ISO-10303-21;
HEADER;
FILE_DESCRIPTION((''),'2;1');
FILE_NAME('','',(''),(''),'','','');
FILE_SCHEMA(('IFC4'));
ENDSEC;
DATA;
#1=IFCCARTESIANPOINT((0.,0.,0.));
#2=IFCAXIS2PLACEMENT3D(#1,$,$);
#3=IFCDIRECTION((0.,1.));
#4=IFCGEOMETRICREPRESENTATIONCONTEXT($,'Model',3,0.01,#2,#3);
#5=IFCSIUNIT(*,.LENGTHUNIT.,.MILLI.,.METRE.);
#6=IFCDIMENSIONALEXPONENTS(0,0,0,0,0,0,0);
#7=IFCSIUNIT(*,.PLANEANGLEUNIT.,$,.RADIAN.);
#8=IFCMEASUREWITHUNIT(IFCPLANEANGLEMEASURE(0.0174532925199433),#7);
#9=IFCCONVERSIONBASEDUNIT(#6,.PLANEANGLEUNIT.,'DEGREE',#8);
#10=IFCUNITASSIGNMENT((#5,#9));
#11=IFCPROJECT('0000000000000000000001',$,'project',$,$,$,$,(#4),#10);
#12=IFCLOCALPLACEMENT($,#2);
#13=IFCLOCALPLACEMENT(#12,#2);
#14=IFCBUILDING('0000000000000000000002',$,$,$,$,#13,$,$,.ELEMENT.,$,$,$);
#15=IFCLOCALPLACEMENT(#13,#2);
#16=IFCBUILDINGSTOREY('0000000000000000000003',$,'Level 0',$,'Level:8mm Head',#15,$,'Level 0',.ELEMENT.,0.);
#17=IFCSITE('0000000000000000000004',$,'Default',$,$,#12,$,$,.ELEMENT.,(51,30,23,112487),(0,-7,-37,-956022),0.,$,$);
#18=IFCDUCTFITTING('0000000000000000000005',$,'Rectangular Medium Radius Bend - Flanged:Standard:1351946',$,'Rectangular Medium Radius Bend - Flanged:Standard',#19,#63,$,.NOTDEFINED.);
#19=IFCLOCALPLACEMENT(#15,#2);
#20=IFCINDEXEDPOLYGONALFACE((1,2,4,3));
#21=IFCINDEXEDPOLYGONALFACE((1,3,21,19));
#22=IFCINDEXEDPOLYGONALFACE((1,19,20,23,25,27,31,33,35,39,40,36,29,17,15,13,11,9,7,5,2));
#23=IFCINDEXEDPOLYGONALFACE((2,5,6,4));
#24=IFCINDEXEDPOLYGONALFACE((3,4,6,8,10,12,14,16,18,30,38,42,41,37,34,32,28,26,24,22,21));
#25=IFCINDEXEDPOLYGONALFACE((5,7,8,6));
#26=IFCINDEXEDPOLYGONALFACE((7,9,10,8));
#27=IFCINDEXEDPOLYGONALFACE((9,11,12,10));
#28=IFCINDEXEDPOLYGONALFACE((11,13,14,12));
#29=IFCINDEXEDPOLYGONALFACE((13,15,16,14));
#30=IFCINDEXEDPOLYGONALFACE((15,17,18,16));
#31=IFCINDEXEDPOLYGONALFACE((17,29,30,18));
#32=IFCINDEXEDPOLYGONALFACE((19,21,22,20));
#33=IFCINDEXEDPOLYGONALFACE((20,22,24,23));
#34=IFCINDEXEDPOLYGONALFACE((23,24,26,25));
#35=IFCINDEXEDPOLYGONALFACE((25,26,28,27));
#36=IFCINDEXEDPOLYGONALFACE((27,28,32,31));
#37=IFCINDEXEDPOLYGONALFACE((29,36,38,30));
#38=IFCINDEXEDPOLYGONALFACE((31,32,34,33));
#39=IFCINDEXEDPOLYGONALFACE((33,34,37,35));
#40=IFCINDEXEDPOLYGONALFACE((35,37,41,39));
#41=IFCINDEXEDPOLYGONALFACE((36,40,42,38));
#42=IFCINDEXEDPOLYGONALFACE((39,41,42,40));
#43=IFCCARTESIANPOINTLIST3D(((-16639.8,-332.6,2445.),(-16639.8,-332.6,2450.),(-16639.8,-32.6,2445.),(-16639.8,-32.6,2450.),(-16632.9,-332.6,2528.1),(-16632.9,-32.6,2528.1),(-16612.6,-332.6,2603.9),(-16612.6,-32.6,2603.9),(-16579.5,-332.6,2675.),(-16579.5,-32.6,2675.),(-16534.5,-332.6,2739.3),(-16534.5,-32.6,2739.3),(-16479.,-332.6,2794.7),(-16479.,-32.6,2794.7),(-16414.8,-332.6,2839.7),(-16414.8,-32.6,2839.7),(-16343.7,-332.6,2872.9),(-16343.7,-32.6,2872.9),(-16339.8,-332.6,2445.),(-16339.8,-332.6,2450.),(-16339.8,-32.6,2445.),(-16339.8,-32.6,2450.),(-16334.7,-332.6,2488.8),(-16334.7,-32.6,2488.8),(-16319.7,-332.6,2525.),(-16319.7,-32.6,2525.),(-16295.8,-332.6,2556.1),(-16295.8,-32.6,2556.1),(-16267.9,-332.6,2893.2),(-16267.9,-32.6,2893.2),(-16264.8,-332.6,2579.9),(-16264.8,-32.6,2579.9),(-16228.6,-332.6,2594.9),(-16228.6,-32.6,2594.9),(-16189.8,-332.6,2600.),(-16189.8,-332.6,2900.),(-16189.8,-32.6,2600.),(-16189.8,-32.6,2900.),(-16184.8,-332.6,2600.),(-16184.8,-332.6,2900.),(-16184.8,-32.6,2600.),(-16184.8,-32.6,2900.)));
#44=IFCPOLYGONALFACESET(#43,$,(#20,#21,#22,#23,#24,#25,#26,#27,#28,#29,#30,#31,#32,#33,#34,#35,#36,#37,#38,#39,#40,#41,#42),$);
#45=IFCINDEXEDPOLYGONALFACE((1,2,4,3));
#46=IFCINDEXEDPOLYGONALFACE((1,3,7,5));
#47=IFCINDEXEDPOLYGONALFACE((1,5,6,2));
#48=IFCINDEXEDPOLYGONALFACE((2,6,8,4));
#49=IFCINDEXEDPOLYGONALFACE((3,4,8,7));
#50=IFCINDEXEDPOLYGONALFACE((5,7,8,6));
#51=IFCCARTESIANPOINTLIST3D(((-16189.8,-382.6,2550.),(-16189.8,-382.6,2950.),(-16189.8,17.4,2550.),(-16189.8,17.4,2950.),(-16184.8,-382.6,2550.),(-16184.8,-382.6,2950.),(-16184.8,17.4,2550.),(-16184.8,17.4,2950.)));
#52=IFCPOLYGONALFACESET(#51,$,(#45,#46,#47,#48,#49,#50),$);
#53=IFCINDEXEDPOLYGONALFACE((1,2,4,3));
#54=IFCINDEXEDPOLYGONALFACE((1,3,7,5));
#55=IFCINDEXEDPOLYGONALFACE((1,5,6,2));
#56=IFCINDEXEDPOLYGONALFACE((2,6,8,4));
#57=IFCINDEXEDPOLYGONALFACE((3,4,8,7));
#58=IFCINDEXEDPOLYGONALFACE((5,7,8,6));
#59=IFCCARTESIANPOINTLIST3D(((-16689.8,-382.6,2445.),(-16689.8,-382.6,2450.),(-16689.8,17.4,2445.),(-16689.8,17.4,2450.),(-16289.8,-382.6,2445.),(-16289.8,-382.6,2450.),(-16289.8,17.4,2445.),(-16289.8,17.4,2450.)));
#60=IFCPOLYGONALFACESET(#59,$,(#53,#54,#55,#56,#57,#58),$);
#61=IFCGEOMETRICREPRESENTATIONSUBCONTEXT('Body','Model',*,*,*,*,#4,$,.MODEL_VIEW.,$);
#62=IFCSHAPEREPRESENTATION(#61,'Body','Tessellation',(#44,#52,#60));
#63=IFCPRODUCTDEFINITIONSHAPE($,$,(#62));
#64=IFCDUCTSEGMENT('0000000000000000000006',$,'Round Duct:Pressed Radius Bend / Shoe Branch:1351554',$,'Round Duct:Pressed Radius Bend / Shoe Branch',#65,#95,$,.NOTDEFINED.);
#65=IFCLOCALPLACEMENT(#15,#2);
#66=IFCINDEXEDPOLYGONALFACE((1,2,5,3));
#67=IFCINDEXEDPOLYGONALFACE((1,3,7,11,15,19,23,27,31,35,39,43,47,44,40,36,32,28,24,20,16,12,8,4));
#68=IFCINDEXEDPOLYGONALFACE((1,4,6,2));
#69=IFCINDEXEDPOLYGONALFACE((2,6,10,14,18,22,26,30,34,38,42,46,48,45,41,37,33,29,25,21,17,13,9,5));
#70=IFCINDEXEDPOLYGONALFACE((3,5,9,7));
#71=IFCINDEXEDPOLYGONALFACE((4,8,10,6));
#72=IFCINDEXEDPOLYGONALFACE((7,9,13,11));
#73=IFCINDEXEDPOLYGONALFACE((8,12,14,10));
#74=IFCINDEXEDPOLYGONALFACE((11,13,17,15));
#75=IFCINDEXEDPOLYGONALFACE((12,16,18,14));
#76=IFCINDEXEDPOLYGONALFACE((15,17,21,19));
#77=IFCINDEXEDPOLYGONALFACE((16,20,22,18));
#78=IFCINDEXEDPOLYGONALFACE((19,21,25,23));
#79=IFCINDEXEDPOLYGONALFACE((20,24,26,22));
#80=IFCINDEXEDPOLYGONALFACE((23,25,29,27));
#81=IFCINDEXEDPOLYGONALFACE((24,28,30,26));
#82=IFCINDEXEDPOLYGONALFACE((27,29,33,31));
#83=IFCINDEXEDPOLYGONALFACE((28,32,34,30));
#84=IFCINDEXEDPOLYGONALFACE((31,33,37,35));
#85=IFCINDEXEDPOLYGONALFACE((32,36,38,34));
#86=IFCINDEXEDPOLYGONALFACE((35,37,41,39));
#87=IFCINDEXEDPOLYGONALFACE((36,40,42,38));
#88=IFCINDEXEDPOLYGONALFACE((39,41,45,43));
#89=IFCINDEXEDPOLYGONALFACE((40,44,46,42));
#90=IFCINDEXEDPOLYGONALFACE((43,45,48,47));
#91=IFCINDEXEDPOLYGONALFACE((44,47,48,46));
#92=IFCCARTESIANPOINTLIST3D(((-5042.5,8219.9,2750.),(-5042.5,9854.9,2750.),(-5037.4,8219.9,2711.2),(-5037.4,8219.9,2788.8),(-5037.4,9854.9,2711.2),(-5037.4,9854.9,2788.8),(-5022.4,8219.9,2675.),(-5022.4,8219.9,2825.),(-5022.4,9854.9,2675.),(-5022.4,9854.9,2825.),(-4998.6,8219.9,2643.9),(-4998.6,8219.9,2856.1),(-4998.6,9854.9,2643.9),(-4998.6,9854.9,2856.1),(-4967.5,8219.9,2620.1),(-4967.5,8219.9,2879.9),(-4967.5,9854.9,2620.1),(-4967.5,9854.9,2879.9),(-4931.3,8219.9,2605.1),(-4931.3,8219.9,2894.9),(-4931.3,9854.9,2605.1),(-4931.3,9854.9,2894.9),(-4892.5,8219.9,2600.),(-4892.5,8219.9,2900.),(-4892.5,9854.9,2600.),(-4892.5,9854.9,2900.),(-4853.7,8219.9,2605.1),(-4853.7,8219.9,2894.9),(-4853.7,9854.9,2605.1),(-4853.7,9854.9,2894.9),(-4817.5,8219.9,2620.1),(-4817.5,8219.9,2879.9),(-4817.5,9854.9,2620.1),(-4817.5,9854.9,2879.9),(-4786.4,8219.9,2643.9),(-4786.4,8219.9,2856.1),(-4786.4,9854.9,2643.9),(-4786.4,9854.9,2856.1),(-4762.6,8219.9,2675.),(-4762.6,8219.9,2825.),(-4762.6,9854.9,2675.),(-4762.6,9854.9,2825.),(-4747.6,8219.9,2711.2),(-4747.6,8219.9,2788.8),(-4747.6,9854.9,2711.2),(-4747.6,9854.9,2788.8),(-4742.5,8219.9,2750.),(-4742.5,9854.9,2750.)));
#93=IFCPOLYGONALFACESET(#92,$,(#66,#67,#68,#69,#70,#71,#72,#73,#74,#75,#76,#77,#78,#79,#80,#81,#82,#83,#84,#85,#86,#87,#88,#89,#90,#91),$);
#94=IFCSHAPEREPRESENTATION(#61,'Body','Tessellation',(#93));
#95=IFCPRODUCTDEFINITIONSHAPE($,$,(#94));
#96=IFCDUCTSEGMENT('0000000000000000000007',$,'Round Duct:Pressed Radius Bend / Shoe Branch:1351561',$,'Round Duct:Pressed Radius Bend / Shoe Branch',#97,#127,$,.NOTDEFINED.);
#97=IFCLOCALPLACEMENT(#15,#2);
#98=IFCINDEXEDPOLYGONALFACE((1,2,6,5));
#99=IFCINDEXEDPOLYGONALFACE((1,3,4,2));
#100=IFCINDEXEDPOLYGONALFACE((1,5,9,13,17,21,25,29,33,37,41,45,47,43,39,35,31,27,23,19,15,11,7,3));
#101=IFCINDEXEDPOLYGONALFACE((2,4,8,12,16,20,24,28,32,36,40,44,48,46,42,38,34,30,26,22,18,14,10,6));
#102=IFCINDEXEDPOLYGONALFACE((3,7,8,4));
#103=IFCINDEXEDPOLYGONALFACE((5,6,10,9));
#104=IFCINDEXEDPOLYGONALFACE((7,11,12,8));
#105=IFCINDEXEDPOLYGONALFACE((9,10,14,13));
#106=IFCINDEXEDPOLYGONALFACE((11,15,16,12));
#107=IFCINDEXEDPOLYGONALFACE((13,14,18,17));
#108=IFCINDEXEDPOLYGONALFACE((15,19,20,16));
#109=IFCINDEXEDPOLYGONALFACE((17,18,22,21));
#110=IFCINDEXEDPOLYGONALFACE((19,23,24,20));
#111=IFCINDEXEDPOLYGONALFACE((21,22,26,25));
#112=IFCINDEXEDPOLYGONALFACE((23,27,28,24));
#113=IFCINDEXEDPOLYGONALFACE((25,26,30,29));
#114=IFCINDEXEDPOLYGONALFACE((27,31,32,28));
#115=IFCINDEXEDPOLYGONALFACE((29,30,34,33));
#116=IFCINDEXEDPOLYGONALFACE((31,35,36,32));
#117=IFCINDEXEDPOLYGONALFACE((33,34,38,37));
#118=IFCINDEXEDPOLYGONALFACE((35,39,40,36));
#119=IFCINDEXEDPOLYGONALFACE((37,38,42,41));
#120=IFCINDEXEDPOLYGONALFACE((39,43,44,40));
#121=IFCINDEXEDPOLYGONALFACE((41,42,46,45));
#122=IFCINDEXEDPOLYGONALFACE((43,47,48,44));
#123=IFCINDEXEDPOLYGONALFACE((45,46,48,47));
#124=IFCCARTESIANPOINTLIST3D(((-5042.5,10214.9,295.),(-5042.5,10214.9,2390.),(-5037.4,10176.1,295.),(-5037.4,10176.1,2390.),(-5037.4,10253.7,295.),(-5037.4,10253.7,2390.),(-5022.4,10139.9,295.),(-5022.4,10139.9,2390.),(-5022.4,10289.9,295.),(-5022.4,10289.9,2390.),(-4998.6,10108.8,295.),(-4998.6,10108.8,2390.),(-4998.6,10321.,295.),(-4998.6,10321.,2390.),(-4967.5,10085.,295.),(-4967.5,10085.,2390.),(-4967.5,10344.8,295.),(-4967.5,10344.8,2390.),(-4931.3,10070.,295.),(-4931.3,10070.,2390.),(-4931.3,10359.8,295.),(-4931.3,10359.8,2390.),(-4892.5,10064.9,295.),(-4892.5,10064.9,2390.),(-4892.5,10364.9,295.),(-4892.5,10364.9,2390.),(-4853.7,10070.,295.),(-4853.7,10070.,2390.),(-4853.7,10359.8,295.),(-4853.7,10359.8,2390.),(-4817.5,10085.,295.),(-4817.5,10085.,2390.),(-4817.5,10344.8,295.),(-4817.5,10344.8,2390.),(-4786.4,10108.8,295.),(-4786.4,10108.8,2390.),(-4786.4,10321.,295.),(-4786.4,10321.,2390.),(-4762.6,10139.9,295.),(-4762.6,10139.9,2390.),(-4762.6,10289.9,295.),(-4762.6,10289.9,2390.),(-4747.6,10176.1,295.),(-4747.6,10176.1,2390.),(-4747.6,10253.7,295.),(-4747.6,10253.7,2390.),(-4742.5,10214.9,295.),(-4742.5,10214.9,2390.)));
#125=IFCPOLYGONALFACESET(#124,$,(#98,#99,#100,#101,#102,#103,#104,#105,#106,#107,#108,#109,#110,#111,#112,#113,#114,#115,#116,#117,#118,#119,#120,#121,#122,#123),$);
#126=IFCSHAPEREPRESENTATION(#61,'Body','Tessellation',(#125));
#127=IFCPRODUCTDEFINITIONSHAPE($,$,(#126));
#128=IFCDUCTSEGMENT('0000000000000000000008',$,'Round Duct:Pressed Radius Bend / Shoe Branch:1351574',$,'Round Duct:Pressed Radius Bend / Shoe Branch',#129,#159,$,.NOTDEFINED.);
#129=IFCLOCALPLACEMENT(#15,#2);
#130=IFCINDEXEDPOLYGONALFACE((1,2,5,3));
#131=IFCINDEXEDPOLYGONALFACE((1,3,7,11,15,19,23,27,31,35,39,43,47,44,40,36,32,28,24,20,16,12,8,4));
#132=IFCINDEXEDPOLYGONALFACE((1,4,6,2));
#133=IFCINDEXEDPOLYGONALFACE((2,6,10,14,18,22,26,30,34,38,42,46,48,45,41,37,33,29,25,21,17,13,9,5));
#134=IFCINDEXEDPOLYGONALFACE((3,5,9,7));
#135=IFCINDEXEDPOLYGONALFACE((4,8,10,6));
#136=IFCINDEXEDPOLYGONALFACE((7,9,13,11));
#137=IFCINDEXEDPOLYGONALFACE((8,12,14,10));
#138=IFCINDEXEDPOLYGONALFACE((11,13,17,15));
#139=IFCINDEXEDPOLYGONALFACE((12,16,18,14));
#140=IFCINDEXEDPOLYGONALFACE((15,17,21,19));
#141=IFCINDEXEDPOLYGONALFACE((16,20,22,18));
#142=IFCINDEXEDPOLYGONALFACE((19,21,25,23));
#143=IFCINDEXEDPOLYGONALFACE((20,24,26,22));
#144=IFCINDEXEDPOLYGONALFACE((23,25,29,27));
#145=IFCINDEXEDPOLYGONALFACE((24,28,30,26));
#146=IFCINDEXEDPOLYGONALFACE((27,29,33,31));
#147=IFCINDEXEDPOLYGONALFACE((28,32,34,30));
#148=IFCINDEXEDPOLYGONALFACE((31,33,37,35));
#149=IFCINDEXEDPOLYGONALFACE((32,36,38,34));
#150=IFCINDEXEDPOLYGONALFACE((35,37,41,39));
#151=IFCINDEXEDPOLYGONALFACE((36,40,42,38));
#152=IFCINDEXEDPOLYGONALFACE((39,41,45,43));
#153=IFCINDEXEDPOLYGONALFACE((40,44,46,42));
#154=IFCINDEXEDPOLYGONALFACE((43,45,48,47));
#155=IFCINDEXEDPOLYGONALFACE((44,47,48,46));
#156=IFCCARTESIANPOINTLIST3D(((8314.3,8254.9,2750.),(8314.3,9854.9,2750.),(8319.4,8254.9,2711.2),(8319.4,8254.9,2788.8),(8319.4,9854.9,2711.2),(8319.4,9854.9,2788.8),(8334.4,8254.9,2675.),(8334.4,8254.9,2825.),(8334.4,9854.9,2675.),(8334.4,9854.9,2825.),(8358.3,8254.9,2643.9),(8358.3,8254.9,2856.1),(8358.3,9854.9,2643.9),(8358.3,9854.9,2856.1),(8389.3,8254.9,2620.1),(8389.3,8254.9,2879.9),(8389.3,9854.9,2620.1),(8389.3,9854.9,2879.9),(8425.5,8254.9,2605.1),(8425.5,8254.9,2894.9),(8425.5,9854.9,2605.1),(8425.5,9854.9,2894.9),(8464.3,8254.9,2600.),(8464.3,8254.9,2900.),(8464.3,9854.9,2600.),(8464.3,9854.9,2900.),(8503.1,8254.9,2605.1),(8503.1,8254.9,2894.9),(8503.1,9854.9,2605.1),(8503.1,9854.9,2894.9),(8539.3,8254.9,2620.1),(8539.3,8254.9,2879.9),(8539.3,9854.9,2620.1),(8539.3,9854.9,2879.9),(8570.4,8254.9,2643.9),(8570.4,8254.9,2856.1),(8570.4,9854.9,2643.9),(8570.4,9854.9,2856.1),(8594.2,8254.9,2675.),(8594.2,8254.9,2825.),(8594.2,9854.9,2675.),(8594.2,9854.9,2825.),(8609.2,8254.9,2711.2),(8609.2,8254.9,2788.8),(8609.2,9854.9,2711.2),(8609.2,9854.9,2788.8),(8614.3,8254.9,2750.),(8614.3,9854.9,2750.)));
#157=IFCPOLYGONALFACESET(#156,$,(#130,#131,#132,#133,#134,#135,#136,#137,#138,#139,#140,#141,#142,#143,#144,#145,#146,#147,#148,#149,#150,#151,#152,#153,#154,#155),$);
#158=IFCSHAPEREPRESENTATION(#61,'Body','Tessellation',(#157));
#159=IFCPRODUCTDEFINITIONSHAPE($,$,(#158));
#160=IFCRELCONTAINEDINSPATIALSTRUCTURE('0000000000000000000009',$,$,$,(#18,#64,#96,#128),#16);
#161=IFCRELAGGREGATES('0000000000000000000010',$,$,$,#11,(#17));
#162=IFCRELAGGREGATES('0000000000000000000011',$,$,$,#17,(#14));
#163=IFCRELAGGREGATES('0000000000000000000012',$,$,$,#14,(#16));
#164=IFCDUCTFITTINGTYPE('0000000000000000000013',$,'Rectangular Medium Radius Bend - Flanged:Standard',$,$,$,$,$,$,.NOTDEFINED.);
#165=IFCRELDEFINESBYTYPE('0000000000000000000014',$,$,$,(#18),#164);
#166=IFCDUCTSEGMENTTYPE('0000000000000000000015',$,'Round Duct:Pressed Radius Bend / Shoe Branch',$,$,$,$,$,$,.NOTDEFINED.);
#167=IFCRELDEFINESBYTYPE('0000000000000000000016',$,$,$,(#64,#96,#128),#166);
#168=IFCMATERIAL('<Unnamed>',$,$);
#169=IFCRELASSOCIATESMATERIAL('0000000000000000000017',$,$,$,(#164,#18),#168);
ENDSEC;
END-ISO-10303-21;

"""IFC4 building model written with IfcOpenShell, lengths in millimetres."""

from ifc_helpers import new_model, entity, si_unit, converted_unit, direction, frame, origin, place, context, subcontext, project, spatial, line, arc, indexed_curve, outline, extrude, source, transform, mapped, material, type_object, type_shapes, element, save


model = new_model("IFC4")

# Units and contexts
model_context = context("Model", 3, precision=0.01, world=origin(), true_north=direction((0.0, 1.0)))
body_context = subcontext(model_context, "Body", "Model", "MODEL_VIEW")
ifc_project = project(units=[si_unit("LENGTHUNIT", "METRE", prefix="MILLI"), converted_unit("PLANEANGLEUNIT", "DEGREE", entity("IfcPlaneAngleMeasure", 0.0174532925199433), si_unit("PLANEANGLEUNIT", "RADIAN"), dimensions=[0, 0, 0, 0, 0, 0, 0])], contexts=[model_context])

# Site, building, storey
site_placement = place(None, origin())
site = spatial("IfcSite", under=ifc_project, at=site_placement, Name="Default", CompositionType="ELEMENT", RefLatitude=(51, 30, 23, 112487), RefLongitude=(0, -7, -37, -956022), RefElevation=0.0)
building_placement = place(site_placement, origin())
building = spatial("IfcBuilding", under=site, at=building_placement, CompositionType="ELEMENT")
storey_placement = place(building_placement, origin())
storey = spatial("IfcBuildingStorey", under=building, at=storey_placement, Name="Level 0", ObjectType="Level:8mm Head", LongName="Level 0", CompositionType="ELEMENT", Elevation=0.0)

# Duct fitting
ifc_material = material(Name="<Unnamed>")
duct_fitting_type = type_object("IfcDuctFittingType", Name="Rectangular Medium Radius Bend - Flanged:Standard", PredefinedType="NOTDEFINED", material=ifc_material)
shared_shape = source(origin(), body_context, "Body", "SweptSolid", [
    extrude(outline(indexed_curve([(-153.8, -301.2), (-148.7, -301.2), (169.4, -169.4), (301.3, 148.7), (301.3, 153.7), (1.3, 153.8), (1.3, 148.8), (-42.7, 42.7), (-148.7, -1.2), (-153.8, -1.2)], segments=[line(1, 2), arc(2, 3, 4), line(4, 5, 6, 7), arc(7, 8, 9), line(9, 10, 1)], self_intersect=False)), frame((-151.2, 151.2, -150.0)), (0.0, 0.0, 1.0), 300.0),
    extrude(outline(indexed_curve([(-2.5, -200.0), (2.5, -200.0), (2.5, 200.0), (-2.5, 200.0), (-2.5, -200.0)], self_intersect=False)), frame((0.0, 302.5, -200.0), z_axis=(0.0, 0.0, 1.0), x_axis=(0.0, 1.0, 0.0)), (0.0, 0.0, 1.0), 400.0),
    extrude(outline(indexed_curve([(-2.5, -200.0), (2.5, -200.0), (2.5, 200.0), (-2.5, 200.0), (-2.5, -200.0)], self_intersect=False)), frame((-302.5, 0.0, -200.0)), (0.0, 0.0, 1.0), 400.0),
])
type_shapes(duct_fitting_type, [shared_shape])
for number, where, z_axis, x_axis, name in (
    (1, (-16489.8, -182.6, 2750.0), (0.0, 1.0, 0.0), (0.0, 0.0, 1.0), "Rectangular Medium Radius Bend - Flanged:Standard:1351946"),
):
    element("IfcDuctFitting", number, at=place(storey_placement, frame(where, z_axis=z_axis, x_axis=x_axis)), inside=storey, type_object=duct_fitting_type, material=ifc_material, Name=name, ObjectType="Rectangular Medium Radius Bend - Flanged:Standard", PredefinedType="NOTDEFINED", context=body_context, shape_type="MappedRepresentation", body=[
        mapped(shared_shape, transform((0.0, 0.0, 0.0), scale=1.0)),
    ])

# Duct segments
duct_segment_type_1 = type_object("IfcDuctSegmentType", Name="Round Duct:Pressed Radius Bend / Shoe Branch", PredefinedType="NOTDEFINED")
duct_segment_1_placement = place(storey_placement, origin())
element("IfcDuctSegment", 2, at=duct_segment_1_placement, inside=storey, type_object=duct_segment_type_1, Name="Round Duct:Pressed Radius Bend / Shoe Branch:1351554", ObjectType="Round Duct:Pressed Radius Bend / Shoe Branch", PredefinedType="NOTDEFINED", context=body_context, shape_type="SweptSolid", body=[
    extrude(outline(indexed_curve([(150.0, 0.0), (106.1, 106.1), (0.0, 150.0), (-106.1, 106.1), (-150.0, 0.0), (-106.1, -106.1), (0.0, -150.0), (106.1, -106.1)], segments=[arc(1, 2, 3), arc(3, 4, 5), arc(5, 6, 7), arc(7, 8, 1)], self_intersect=False)), frame((-4892.5, 8219.9, 2750.0), z_axis=(0.0, 1.0, 0.0), x_axis=(1.0, 0.0, 0.0)), (0.0, 0.0, 1.0), 1635.0),
])
duct_segment_2_placement = place(storey_placement, origin())
element("IfcDuctSegment", 3, at=duct_segment_2_placement, inside=storey, type_object=duct_segment_type_1, Name="Round Duct:Pressed Radius Bend / Shoe Branch:1351561", ObjectType="Round Duct:Pressed Radius Bend / Shoe Branch", PredefinedType="NOTDEFINED", context=body_context, shape_type="SweptSolid", body=[
    extrude(outline(indexed_curve([(150.0, 0.0), (106.1, 106.1), (0.0, 150.0), (-106.1, 106.1), (-150.0, 0.0), (-106.1, -106.1), (0.0, -150.0), (106.1, -106.1)], segments=[arc(1, 2, 3), arc(3, 4, 5), arc(5, 6, 7), arc(7, 8, 1)], self_intersect=False)), frame((-4892.5, 10214.9, 295.0)), (0.0, 0.0, 1.0), 2095.0),
])
duct_segment_3_placement = place(storey_placement, origin())
element("IfcDuctSegment", 4, at=duct_segment_3_placement, inside=storey, type_object=duct_segment_type_1, Name="Round Duct:Pressed Radius Bend / Shoe Branch:1351574", ObjectType="Round Duct:Pressed Radius Bend / Shoe Branch", PredefinedType="NOTDEFINED", context=body_context, shape_type="SweptSolid", body=[
    extrude(outline(indexed_curve([(150.0, 0.0), (106.1, 106.1), (0.0, 150.0), (-106.1, 106.1), (-150.0, 0.0), (-106.1, -106.1), (0.0, -150.0), (106.1, -106.1)], segments=[arc(1, 2, 3), arc(3, 4, 5), arc(5, 6, 7), arc(7, 8, 1)], self_intersect=False)), frame((8464.3, 8254.9, 2750.0), z_axis=(0.0, 1.0, 0.0), x_axis=(-1.0, 0.0, 0.0)), (0.0, 0.0, 1.0), 1600.0),
])

save(model, "model.ifc")
